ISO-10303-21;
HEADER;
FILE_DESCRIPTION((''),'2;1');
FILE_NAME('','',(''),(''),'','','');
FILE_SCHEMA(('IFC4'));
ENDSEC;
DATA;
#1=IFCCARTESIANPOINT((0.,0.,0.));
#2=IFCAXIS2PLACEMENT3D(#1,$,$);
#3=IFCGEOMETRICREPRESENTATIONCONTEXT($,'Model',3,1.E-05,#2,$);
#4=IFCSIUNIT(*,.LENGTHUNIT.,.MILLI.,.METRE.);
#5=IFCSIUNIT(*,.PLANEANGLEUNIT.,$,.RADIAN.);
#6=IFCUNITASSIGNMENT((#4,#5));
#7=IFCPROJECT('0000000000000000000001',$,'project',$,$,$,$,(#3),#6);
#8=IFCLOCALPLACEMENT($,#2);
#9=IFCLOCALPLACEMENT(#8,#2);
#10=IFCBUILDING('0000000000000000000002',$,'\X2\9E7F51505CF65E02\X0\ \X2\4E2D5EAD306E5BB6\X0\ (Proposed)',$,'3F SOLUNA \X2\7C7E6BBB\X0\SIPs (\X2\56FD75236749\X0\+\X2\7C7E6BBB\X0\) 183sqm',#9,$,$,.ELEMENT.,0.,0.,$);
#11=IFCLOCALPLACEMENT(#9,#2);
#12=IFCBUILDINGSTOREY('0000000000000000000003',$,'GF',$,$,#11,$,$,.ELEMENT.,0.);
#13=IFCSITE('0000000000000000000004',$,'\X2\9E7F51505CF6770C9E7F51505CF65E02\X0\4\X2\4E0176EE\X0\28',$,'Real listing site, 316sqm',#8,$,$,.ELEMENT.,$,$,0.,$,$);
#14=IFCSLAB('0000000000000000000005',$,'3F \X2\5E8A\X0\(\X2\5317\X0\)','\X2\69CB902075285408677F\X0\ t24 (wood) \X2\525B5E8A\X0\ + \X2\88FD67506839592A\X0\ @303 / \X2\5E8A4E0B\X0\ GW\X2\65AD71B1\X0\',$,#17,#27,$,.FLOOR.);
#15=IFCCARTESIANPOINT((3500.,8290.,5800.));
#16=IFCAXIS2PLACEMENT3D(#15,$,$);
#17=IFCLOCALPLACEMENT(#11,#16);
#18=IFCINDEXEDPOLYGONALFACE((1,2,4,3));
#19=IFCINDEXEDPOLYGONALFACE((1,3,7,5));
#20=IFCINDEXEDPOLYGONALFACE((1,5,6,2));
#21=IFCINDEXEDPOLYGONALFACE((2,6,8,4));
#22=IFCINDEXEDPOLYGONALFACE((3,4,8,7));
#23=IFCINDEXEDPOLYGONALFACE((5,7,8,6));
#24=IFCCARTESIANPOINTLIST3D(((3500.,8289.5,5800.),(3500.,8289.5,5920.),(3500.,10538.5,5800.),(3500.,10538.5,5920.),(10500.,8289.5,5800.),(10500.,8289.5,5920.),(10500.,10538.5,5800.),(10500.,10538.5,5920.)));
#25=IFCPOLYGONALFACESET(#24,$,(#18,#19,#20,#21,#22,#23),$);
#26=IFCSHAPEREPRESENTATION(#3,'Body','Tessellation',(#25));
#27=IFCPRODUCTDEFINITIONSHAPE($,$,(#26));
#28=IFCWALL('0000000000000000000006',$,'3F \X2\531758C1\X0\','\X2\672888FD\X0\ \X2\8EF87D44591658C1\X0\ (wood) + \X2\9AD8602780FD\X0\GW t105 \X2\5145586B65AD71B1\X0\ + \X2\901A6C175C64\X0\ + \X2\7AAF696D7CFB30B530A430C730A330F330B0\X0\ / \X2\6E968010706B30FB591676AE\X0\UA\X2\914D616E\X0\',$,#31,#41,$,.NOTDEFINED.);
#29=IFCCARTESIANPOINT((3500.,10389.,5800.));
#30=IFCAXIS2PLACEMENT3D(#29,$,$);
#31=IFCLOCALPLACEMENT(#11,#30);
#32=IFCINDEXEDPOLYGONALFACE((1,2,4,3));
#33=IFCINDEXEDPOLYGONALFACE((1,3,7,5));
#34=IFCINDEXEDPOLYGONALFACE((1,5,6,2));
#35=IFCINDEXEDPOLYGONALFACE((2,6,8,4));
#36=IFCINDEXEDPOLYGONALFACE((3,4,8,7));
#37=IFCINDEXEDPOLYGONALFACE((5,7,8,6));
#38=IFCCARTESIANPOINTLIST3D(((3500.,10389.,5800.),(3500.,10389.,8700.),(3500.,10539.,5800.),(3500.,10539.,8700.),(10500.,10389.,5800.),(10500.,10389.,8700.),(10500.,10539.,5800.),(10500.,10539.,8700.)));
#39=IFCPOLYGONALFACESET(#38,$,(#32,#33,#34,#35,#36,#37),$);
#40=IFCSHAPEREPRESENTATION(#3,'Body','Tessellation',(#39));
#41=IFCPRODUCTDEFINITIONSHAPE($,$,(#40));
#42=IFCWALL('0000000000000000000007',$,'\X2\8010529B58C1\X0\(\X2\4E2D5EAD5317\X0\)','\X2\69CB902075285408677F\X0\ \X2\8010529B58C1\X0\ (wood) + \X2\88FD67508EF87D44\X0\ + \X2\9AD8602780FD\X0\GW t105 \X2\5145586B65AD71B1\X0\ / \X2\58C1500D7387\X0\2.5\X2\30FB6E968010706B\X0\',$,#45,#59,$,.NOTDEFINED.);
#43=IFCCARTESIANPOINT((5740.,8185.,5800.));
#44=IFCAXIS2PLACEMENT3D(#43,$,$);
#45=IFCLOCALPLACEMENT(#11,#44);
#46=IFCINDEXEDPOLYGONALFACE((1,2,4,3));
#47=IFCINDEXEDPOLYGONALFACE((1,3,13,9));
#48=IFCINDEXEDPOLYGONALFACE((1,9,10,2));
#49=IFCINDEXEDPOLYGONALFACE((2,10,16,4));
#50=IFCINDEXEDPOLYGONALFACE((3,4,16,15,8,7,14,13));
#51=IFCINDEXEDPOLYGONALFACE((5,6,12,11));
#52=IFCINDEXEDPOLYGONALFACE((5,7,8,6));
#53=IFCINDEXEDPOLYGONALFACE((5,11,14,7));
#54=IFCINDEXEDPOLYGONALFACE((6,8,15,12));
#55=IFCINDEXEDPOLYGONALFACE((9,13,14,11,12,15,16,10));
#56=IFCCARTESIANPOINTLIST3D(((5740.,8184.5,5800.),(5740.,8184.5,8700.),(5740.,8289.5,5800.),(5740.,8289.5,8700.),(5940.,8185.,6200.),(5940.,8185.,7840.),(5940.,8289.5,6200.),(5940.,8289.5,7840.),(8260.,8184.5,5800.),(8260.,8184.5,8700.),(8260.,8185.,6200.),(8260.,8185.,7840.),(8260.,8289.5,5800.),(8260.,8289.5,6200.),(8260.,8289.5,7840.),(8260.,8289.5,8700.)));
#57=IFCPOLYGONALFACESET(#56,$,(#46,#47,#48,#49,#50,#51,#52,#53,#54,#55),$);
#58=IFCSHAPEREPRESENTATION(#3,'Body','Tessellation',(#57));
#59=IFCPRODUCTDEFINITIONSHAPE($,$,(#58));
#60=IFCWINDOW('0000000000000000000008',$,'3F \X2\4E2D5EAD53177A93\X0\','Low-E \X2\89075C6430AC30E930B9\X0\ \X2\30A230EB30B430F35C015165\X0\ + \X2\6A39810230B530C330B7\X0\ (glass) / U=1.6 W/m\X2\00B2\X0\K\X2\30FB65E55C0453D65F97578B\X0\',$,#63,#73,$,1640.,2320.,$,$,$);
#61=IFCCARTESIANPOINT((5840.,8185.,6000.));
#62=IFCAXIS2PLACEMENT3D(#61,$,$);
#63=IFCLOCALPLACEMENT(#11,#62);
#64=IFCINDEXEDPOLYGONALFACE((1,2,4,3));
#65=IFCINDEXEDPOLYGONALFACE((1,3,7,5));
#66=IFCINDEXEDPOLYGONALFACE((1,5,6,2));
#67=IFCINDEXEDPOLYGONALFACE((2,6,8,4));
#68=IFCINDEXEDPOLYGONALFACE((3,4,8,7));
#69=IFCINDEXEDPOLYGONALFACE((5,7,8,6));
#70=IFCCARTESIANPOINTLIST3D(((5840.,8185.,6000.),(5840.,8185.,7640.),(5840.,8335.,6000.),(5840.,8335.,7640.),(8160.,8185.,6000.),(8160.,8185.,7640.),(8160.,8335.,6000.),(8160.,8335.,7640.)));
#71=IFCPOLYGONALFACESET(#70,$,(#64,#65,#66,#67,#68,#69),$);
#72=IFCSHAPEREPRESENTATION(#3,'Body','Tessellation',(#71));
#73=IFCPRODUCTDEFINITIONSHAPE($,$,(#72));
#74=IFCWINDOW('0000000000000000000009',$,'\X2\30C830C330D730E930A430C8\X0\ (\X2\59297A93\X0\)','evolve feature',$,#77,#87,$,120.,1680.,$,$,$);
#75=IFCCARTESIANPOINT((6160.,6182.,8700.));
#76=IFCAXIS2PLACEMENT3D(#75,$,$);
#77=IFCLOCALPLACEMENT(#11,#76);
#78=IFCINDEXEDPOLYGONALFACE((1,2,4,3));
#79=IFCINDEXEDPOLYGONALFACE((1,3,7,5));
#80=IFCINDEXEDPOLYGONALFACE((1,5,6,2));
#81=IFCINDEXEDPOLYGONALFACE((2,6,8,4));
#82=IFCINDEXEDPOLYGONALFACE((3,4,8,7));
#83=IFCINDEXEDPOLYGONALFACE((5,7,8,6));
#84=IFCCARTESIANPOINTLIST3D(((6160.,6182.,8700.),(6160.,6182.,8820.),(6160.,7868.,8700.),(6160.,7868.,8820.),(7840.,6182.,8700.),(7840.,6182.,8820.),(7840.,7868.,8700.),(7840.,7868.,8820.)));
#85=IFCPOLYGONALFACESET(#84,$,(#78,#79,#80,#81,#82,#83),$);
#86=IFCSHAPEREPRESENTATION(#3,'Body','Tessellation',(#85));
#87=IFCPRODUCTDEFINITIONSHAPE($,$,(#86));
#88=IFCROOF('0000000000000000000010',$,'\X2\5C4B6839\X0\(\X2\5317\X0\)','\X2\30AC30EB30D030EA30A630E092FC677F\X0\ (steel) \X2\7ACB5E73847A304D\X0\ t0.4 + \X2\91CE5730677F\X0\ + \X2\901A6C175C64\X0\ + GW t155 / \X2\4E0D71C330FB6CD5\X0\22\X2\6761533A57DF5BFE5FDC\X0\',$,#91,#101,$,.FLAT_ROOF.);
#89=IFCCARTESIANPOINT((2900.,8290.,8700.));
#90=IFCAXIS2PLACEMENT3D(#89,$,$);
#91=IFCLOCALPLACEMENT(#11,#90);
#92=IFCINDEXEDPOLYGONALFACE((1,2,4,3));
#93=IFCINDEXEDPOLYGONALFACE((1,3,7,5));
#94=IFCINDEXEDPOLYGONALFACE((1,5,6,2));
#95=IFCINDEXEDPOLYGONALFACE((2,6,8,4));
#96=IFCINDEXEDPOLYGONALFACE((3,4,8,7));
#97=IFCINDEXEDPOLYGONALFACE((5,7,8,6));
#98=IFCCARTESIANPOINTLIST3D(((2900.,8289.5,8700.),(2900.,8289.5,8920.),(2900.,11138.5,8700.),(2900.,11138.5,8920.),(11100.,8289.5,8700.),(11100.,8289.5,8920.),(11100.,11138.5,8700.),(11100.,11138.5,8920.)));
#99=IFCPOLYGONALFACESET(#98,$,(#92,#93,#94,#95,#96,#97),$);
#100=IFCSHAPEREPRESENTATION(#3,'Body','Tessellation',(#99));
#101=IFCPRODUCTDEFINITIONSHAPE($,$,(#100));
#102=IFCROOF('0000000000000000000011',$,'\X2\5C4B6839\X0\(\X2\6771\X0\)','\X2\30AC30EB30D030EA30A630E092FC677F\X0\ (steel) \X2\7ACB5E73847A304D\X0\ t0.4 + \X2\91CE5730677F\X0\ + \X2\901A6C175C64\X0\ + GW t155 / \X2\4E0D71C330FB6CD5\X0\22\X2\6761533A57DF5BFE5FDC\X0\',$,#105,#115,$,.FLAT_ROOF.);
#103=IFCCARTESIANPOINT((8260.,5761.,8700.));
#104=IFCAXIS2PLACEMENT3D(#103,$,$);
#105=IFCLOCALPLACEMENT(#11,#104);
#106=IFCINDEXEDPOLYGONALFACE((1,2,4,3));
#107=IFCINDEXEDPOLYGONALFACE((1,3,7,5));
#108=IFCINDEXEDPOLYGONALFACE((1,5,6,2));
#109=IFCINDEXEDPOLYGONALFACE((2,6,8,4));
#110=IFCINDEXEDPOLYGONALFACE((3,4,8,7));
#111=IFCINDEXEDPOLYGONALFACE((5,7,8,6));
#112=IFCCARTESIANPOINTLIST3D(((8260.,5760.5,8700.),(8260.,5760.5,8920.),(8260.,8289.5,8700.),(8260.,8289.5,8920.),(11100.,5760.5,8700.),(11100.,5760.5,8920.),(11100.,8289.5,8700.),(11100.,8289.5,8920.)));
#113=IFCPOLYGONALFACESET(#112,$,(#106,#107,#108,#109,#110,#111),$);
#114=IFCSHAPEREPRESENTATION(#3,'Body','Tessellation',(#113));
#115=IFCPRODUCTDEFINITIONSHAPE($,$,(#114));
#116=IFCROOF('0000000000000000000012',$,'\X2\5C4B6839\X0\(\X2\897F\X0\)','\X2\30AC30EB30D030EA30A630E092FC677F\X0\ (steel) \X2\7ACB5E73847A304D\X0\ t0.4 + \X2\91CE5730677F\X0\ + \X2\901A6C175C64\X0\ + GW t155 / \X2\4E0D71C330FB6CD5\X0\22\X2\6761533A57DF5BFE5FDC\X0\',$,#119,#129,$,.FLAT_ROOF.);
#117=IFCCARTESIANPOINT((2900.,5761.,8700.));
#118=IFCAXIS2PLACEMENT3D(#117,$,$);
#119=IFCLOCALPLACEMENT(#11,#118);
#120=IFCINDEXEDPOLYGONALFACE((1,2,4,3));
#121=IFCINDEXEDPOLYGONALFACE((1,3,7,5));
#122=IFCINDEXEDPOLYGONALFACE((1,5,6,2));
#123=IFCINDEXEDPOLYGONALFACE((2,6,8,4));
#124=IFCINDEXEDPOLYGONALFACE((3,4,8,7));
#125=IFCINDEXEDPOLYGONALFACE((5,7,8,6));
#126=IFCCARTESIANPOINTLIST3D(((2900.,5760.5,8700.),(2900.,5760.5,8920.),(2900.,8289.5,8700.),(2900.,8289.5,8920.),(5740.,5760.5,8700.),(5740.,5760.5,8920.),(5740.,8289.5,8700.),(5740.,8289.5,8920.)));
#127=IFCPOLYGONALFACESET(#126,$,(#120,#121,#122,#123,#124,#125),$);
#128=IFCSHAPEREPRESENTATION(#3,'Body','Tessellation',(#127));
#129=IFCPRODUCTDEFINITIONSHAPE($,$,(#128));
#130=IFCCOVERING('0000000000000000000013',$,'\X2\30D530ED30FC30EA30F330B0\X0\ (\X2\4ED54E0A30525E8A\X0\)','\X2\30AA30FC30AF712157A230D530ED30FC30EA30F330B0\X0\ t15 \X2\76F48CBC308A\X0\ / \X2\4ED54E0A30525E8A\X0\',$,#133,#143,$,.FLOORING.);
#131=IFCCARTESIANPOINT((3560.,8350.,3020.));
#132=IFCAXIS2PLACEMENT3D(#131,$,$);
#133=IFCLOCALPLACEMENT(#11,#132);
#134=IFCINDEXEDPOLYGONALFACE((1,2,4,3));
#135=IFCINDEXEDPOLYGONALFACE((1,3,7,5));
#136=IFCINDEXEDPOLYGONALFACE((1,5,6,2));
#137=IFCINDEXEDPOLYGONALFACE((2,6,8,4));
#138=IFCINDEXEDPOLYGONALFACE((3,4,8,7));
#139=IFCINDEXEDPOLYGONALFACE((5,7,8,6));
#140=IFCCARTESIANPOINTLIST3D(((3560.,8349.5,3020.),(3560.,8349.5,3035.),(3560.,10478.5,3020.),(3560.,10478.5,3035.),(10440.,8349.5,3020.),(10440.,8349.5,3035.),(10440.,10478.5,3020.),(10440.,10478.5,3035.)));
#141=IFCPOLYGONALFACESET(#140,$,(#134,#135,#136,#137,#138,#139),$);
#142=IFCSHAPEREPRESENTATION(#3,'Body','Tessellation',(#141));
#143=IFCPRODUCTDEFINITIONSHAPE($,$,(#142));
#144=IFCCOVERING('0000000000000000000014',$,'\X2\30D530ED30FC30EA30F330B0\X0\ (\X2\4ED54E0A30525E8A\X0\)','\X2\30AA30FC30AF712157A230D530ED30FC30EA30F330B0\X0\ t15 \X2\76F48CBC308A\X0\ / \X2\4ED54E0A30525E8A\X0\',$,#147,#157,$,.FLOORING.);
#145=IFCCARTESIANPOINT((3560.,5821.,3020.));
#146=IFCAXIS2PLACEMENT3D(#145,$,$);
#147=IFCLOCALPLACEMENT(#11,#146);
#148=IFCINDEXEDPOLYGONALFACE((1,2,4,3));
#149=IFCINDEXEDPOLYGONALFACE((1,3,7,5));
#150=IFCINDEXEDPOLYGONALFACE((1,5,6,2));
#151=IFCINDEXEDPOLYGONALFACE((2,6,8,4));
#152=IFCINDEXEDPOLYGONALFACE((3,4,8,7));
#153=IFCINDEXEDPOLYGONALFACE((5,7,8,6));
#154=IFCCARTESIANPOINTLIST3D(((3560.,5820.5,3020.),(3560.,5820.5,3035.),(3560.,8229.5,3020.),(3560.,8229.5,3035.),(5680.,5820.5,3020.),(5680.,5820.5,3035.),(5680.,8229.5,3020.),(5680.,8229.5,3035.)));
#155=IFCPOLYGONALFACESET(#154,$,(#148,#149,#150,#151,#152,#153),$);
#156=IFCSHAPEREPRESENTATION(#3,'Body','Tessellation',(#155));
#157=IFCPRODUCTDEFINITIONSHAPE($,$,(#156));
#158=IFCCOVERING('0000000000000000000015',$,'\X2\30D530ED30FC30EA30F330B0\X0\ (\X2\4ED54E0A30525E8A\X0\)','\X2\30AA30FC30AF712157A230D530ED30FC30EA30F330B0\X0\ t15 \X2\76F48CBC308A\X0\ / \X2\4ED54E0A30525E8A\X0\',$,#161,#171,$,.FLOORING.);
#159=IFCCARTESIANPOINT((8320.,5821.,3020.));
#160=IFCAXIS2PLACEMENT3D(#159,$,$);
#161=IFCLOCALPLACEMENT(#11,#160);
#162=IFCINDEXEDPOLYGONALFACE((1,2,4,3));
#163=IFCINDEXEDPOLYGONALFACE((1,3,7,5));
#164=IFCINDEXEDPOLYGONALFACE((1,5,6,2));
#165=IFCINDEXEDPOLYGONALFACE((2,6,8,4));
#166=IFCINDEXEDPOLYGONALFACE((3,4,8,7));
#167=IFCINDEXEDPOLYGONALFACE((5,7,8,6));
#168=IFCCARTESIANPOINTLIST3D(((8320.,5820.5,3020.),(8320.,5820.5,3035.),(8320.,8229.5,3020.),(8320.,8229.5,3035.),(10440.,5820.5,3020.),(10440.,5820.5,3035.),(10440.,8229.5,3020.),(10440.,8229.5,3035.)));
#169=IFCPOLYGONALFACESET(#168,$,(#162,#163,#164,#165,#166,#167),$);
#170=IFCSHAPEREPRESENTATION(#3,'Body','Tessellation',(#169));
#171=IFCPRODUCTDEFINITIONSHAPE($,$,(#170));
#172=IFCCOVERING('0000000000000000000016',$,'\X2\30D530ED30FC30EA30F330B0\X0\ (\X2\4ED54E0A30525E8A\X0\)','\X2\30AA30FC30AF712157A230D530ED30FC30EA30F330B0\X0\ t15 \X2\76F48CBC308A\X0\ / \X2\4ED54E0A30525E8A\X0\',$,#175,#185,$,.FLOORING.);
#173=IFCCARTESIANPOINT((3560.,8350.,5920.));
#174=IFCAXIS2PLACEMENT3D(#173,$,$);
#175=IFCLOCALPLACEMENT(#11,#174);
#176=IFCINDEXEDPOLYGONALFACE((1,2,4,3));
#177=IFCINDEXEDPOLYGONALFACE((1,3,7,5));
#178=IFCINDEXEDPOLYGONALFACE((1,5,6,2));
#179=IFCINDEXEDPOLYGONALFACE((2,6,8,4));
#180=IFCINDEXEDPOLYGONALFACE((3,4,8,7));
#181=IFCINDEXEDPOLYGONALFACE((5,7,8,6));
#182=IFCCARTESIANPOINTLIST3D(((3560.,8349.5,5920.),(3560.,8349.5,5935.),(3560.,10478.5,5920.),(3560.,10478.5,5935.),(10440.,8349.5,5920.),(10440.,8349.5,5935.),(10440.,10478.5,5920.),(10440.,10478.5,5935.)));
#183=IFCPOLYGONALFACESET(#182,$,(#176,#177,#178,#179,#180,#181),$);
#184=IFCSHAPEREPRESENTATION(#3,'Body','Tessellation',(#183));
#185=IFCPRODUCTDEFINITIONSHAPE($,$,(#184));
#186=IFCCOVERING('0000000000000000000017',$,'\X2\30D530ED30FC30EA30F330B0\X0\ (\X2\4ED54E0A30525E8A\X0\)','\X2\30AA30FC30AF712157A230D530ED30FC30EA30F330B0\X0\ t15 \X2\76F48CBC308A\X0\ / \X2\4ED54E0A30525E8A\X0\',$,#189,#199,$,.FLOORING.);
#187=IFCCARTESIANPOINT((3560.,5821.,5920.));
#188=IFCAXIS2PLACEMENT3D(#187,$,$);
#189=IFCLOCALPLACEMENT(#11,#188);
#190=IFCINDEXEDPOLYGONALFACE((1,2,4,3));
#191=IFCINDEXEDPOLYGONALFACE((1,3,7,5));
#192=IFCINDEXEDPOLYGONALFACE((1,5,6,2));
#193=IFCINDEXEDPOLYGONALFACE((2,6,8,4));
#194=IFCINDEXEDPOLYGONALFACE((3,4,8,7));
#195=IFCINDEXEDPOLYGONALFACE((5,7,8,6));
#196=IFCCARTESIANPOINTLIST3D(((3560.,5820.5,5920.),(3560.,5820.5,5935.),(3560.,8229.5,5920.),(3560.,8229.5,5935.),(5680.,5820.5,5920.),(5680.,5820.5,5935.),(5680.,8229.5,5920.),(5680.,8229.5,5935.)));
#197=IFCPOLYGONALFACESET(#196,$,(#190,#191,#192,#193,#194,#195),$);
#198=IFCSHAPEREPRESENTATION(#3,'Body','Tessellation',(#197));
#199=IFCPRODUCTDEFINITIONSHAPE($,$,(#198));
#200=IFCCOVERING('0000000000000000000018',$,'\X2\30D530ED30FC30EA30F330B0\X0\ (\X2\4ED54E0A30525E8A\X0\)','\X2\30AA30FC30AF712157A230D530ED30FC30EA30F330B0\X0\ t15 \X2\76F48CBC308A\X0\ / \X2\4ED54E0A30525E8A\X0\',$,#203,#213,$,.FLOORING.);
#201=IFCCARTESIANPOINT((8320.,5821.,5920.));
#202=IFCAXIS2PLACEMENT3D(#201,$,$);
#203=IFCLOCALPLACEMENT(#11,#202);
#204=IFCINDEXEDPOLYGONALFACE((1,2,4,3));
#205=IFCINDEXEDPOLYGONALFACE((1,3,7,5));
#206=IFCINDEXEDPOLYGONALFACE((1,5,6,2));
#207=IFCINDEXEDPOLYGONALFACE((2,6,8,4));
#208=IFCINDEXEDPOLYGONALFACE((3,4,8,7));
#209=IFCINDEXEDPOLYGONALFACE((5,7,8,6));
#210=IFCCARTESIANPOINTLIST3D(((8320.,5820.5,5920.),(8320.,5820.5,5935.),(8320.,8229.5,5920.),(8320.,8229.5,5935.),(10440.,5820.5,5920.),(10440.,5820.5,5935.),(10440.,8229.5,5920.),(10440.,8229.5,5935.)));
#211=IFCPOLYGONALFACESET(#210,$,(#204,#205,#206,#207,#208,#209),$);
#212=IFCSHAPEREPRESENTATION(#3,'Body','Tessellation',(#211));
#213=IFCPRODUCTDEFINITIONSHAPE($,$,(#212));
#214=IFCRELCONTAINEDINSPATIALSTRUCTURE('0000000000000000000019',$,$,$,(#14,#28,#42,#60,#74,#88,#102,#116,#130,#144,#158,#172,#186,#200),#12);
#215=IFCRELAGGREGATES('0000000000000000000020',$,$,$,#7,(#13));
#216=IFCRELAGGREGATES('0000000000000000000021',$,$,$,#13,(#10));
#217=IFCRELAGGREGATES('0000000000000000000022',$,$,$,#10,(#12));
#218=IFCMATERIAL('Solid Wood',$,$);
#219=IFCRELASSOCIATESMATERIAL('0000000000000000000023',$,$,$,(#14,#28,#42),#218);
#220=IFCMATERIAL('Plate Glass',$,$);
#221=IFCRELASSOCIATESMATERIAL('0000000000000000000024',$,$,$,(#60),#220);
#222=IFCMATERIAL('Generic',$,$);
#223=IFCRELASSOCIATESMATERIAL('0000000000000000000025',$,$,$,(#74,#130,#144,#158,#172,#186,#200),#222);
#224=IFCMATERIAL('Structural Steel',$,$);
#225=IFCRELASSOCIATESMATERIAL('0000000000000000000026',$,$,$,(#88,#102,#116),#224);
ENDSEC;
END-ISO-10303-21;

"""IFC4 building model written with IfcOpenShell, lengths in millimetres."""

from ifc_helpers import new_model, si_unit, frame, frame_2d, origin, place, context, project, spatial, rectangle, extrude, material, element, fill, save


model = new_model("IFC4")

# Units and contexts
model_context = context("Model", 3, precision=1e-05, world=origin())
ifc_project = project(units=[si_unit("LENGTHUNIT", "METRE", prefix="MILLI"), si_unit("PLANEANGLEUNIT", "RADIAN")], contexts=[model_context])

# Site, building, storey
site_placement = place(None, origin())
site = spatial("IfcSite", under=ifc_project, at=site_placement, Name="鹿児島県鹿児島市4丁目28", ObjectType="Real listing site, 316sqm", CompositionType="ELEMENT", RefElevation=0.0)
building_placement = place(site_placement, origin())
building = spatial("IfcBuilding", under=site, at=building_placement, Name="鹿児島市 中庭の家 (Proposed)", ObjectType="3F SOLUNA 籾殻SIPs (国産杉+籾殻) 183sqm", CompositionType="ELEMENT", ElevationOfRefHeight=0.0, ElevationOfTerrain=0.0)
storey_placement = place(building_placement, origin())
storey = spatial("IfcBuildingStorey", under=building, at=storey_placement, Name="GF", CompositionType="ELEMENT", Elevation=0.0)

# Slab
ifc_material_1 = material(Name="Solid Wood")
slab_placement = place(storey_placement, frame((3500.0, 8290.0, 5800.0)))
element("IfcSlab", 1, at=slab_placement, inside=storey, material=ifc_material_1, Name="3F 床(北)", Description="構造用合板 t24 (wood) 剛床 + 製材根太 @303 / 床下 GW断熱", PredefinedType="FLOOR", context=model_context, shape_type="SweptSolid", body=[
    extrude(rectangle(XDim=7000.0, YDim=2249.0, at=frame_2d((3500.0, 1124.0))), frame((3500.0, 8290.0, 5800.0)), (0.0, 0.0, 1.0), 120.0),
])

# Wall
wall_1_placement = place(storey_placement, frame((3500.0, 10389.0, 5800.0)))
element("IfcWall", 2, at=wall_1_placement, inside=storey, material=ifc_material_1, Name="3F 北壁", Description="木製 軸組外壁 (wood) + 高性能GW t105 充填断熱 + 通気層 + 窯業系サイディング / 準耐火・外皮UA配慮", PredefinedType="NOTDEFINED", context=model_context, shape_type="SweptSolid", body=[
    extrude(rectangle(XDim=7000.0, YDim=150.0, at=frame_2d((3500.0, 75.0))), frame((3500.0, 10389.0, 5800.0)), (0.0, 0.0, 1.0), 2900.0),
])

# Wall, opening, window
wall_2_placement = place(storey_placement, frame((5740.0, 8185.0, 5800.0)))
wall_2 = element("IfcWall", 3, at=wall_2_placement, inside=storey, material=ifc_material_1, Name="耐力壁(中庭北)", Description="構造用合板 耐力壁 (wood) + 製材軸組 + 高性能GW t105 充填断熱 / 壁倍率2.5・準耐火", PredefinedType="NOTDEFINED", context=model_context, shape_type="SweptSolid", body=[
    extrude(rectangle(XDim=2520.0, YDim=105.0, at=frame_2d((1260.0, 52.0))), frame((5740.0, 8185.0, 5800.0)), (0.0, 0.0, 1.0), 2900.0),
])
opening_placement = place(storey_placement, frame((5840.0, 8185.0, 6000.0)))
opening = element("IfcOpeningElement", 4, at=opening_placement, cuts=wall_2, PredefinedType="NOTDEFINED", context=model_context, shape_type="SweptSolid", body=[
    extrude(rectangle(XDim=2320.0, YDim=150.0, at=frame_2d((1160.0, 75.0))), frame((5840.0, 8185.0, 6000.0)), (0.0, 0.0, 1.0), 1640.0),
])
ifc_material_2 = material(Name="Plate Glass")
window_1_placement = place(storey_placement, frame((5840.0, 8185.0, 6000.0)))
window_1 = element("IfcWindow", 5, at=window_1_placement, inside=storey, material=ifc_material_2, Name="3F 中庭北窓", Description="Low-E 複層ガラス アルゴン封入 + 樹脂サッシ (glass) / U=1.6 W/m²K・日射取得型", OverallHeight=1640.0, OverallWidth=2320.0, context=model_context, shape_type="SweptSolid", body=[
    extrude(rectangle(XDim=2320.0, YDim=150.0, at=frame_2d((1160.0, 75.0))), frame((5840.0, 8185.0, 6000.0)), (0.0, 0.0, 1.0), 1640.0),
])
fill(opening, window_1)

# Window
ifc_material_3 = material(Name="Generic")
window_2_placement = place(storey_placement, frame((6160.0, 6182.0, 8700.0)))
element("IfcWindow", 6, at=window_2_placement, inside=storey, material=ifc_material_3, Name="トップライト (天窓)", Description="evolve feature", OverallHeight=120.0, OverallWidth=1680.0, context=model_context, shape_type="SweptSolid", body=[
    extrude(rectangle(XDim=1680.0, YDim=1686.0, at=frame_2d((840.0, 843.0))), frame((6160.0, 6182.0, 8700.0)), (0.0, 0.0, 1.0), 120.0),
])

# Roofs
ifc_material_4 = material(Name="Structural Steel")
roof_1_placement = place(storey_placement, frame((2900.0, 8290.0, 8700.0)))
element("IfcRoof", 7, at=roof_1_placement, inside=storey, material=ifc_material_4, Name="屋根(北)", Description="ガルバリウム鋼板 (steel) 立平葺き t0.4 + 野地板 + 通気層 + GW t155 / 不燃・法22条区域対応", PredefinedType="FLAT_ROOF", context=model_context, shape_type="SweptSolid", body=[
    extrude(rectangle(XDim=8200.0, YDim=2849.0, at=frame_2d((4100.0, 1424.0))), frame((2900.0, 8290.0, 8700.0)), (0.0, 0.0, 1.0), 220.0),
])
roof_2_placement = place(storey_placement, frame((8260.0, 5761.0, 8700.0)))
element("IfcRoof", 8, at=roof_2_placement, inside=storey, material=ifc_material_4, Name="屋根(東)", Description="ガルバリウム鋼板 (steel) 立平葺き t0.4 + 野地板 + 通気層 + GW t155 / 不燃・法22条区域対応", PredefinedType="FLAT_ROOF", context=model_context, shape_type="SweptSolid", body=[
    extrude(rectangle(XDim=2840.0, YDim=2529.0, at=frame_2d((1420.0, 1264.0))), frame((8260.0, 5761.0, 8700.0)), (0.0, 0.0, 1.0), 220.0),
])
roof_3_placement = place(storey_placement, frame((2900.0, 5761.0, 8700.0)))
element("IfcRoof", 9, at=roof_3_placement, inside=storey, material=ifc_material_4, Name="屋根(西)", Description="ガルバリウム鋼板 (steel) 立平葺き t0.4 + 野地板 + 通気層 + GW t155 / 不燃・法22条区域対応", PredefinedType="FLAT_ROOF", context=model_context, shape_type="SweptSolid", body=[
    extrude(rectangle(XDim=2840.0, YDim=2529.0, at=frame_2d((1420.0, 1264.0))), frame((2900.0, 5761.0, 8700.0)), (0.0, 0.0, 1.0), 220.0),
])

# Coverings
covering_1_placement = place(storey_placement, frame((3560.0, 8350.0, 3020.0)))
element("IfcCovering", 10, at=covering_1_placement, inside=storey, material=ifc_material_3, Name="フローリング (仕上げ床)", Description="オーク無垢フローリング t15 直貼り / 仕上げ床", PredefinedType="FLOORING", context=model_context, shape_type="SweptSolid", body=[
    extrude(rectangle(XDim=6880.0, YDim=2129.0, at=frame_2d((3440.0, 1064.0))), frame((3560.0, 8350.0, 3020.0)), (0.0, 0.0, 1.0), 15.0),
])
covering_2_placement = place(storey_placement, frame((3560.0, 5821.0, 3020.0)))
element("IfcCovering", 11, at=covering_2_placement, inside=storey, material=ifc_material_3, Name="フローリング (仕上げ床)", Description="オーク無垢フローリング t15 直貼り / 仕上げ床", PredefinedType="FLOORING", context=model_context, shape_type="SweptSolid", body=[
    extrude(rectangle(XDim=2120.0, YDim=2409.0, at=frame_2d((1060.0, 1204.0))), frame((3560.0, 5821.0, 3020.0)), (0.0, 0.0, 1.0), 15.0),
])
covering_3_placement = place(storey_placement, frame((8320.0, 5821.0, 3020.0)))
element("IfcCovering", 12, at=covering_3_placement, inside=storey, material=ifc_material_3, Name="フローリング (仕上げ床)", Description="オーク無垢フローリング t15 直貼り / 仕上げ床", PredefinedType="FLOORING", context=model_context, shape_type="SweptSolid", body=[
    extrude(rectangle(XDim=2120.0, YDim=2409.0, at=frame_2d((1060.0, 1204.0))), frame((8320.0, 5821.0, 3020.0)), (0.0, 0.0, 1.0), 15.0),
])
covering_4_placement = place(storey_placement, frame((3560.0, 8350.0, 5920.0)))
element("IfcCovering", 13, at=covering_4_placement, inside=storey, material=ifc_material_3, Name="フローリング (仕上げ床)", Description="オーク無垢フローリング t15 直貼り / 仕上げ床", PredefinedType="FLOORING", context=model_context, shape_type="SweptSolid", body=[
    extrude(rectangle(XDim=6880.0, YDim=2129.0, at=frame_2d((3440.0, 1064.0))), frame((3560.0, 8350.0, 5920.0)), (0.0, 0.0, 1.0), 15.0),
])
covering_5_placement = place(storey_placement, frame((3560.0, 5821.0, 5920.0)))
element("IfcCovering", 14, at=covering_5_placement, inside=storey, material=ifc_material_3, Name="フローリング (仕上げ床)", Description="オーク無垢フローリング t15 直貼り / 仕上げ床", PredefinedType="FLOORING", context=model_context, shape_type="SweptSolid", body=[
    extrude(rectangle(XDim=2120.0, YDim=2409.0, at=frame_2d((1060.0, 1204.0))), frame((3560.0, 5821.0, 5920.0)), (0.0, 0.0, 1.0), 15.0),
])
covering_6_placement = place(storey_placement, frame((8320.0, 5821.0, 5920.0)))
element("IfcCovering", 15, at=covering_6_placement, inside=storey, material=ifc_material_3, Name="フローリング (仕上げ床)", Description="オーク無垢フローリング t15 直貼り / 仕上げ床", PredefinedType="FLOORING", context=model_context, shape_type="SweptSolid", body=[
    extrude(rectangle(XDim=2120.0, YDim=2409.0, at=frame_2d((1060.0, 1204.0))), frame((8320.0, 5821.0, 5920.0)), (0.0, 0.0, 1.0), 15.0),
])

save(model, "model.ifc")
